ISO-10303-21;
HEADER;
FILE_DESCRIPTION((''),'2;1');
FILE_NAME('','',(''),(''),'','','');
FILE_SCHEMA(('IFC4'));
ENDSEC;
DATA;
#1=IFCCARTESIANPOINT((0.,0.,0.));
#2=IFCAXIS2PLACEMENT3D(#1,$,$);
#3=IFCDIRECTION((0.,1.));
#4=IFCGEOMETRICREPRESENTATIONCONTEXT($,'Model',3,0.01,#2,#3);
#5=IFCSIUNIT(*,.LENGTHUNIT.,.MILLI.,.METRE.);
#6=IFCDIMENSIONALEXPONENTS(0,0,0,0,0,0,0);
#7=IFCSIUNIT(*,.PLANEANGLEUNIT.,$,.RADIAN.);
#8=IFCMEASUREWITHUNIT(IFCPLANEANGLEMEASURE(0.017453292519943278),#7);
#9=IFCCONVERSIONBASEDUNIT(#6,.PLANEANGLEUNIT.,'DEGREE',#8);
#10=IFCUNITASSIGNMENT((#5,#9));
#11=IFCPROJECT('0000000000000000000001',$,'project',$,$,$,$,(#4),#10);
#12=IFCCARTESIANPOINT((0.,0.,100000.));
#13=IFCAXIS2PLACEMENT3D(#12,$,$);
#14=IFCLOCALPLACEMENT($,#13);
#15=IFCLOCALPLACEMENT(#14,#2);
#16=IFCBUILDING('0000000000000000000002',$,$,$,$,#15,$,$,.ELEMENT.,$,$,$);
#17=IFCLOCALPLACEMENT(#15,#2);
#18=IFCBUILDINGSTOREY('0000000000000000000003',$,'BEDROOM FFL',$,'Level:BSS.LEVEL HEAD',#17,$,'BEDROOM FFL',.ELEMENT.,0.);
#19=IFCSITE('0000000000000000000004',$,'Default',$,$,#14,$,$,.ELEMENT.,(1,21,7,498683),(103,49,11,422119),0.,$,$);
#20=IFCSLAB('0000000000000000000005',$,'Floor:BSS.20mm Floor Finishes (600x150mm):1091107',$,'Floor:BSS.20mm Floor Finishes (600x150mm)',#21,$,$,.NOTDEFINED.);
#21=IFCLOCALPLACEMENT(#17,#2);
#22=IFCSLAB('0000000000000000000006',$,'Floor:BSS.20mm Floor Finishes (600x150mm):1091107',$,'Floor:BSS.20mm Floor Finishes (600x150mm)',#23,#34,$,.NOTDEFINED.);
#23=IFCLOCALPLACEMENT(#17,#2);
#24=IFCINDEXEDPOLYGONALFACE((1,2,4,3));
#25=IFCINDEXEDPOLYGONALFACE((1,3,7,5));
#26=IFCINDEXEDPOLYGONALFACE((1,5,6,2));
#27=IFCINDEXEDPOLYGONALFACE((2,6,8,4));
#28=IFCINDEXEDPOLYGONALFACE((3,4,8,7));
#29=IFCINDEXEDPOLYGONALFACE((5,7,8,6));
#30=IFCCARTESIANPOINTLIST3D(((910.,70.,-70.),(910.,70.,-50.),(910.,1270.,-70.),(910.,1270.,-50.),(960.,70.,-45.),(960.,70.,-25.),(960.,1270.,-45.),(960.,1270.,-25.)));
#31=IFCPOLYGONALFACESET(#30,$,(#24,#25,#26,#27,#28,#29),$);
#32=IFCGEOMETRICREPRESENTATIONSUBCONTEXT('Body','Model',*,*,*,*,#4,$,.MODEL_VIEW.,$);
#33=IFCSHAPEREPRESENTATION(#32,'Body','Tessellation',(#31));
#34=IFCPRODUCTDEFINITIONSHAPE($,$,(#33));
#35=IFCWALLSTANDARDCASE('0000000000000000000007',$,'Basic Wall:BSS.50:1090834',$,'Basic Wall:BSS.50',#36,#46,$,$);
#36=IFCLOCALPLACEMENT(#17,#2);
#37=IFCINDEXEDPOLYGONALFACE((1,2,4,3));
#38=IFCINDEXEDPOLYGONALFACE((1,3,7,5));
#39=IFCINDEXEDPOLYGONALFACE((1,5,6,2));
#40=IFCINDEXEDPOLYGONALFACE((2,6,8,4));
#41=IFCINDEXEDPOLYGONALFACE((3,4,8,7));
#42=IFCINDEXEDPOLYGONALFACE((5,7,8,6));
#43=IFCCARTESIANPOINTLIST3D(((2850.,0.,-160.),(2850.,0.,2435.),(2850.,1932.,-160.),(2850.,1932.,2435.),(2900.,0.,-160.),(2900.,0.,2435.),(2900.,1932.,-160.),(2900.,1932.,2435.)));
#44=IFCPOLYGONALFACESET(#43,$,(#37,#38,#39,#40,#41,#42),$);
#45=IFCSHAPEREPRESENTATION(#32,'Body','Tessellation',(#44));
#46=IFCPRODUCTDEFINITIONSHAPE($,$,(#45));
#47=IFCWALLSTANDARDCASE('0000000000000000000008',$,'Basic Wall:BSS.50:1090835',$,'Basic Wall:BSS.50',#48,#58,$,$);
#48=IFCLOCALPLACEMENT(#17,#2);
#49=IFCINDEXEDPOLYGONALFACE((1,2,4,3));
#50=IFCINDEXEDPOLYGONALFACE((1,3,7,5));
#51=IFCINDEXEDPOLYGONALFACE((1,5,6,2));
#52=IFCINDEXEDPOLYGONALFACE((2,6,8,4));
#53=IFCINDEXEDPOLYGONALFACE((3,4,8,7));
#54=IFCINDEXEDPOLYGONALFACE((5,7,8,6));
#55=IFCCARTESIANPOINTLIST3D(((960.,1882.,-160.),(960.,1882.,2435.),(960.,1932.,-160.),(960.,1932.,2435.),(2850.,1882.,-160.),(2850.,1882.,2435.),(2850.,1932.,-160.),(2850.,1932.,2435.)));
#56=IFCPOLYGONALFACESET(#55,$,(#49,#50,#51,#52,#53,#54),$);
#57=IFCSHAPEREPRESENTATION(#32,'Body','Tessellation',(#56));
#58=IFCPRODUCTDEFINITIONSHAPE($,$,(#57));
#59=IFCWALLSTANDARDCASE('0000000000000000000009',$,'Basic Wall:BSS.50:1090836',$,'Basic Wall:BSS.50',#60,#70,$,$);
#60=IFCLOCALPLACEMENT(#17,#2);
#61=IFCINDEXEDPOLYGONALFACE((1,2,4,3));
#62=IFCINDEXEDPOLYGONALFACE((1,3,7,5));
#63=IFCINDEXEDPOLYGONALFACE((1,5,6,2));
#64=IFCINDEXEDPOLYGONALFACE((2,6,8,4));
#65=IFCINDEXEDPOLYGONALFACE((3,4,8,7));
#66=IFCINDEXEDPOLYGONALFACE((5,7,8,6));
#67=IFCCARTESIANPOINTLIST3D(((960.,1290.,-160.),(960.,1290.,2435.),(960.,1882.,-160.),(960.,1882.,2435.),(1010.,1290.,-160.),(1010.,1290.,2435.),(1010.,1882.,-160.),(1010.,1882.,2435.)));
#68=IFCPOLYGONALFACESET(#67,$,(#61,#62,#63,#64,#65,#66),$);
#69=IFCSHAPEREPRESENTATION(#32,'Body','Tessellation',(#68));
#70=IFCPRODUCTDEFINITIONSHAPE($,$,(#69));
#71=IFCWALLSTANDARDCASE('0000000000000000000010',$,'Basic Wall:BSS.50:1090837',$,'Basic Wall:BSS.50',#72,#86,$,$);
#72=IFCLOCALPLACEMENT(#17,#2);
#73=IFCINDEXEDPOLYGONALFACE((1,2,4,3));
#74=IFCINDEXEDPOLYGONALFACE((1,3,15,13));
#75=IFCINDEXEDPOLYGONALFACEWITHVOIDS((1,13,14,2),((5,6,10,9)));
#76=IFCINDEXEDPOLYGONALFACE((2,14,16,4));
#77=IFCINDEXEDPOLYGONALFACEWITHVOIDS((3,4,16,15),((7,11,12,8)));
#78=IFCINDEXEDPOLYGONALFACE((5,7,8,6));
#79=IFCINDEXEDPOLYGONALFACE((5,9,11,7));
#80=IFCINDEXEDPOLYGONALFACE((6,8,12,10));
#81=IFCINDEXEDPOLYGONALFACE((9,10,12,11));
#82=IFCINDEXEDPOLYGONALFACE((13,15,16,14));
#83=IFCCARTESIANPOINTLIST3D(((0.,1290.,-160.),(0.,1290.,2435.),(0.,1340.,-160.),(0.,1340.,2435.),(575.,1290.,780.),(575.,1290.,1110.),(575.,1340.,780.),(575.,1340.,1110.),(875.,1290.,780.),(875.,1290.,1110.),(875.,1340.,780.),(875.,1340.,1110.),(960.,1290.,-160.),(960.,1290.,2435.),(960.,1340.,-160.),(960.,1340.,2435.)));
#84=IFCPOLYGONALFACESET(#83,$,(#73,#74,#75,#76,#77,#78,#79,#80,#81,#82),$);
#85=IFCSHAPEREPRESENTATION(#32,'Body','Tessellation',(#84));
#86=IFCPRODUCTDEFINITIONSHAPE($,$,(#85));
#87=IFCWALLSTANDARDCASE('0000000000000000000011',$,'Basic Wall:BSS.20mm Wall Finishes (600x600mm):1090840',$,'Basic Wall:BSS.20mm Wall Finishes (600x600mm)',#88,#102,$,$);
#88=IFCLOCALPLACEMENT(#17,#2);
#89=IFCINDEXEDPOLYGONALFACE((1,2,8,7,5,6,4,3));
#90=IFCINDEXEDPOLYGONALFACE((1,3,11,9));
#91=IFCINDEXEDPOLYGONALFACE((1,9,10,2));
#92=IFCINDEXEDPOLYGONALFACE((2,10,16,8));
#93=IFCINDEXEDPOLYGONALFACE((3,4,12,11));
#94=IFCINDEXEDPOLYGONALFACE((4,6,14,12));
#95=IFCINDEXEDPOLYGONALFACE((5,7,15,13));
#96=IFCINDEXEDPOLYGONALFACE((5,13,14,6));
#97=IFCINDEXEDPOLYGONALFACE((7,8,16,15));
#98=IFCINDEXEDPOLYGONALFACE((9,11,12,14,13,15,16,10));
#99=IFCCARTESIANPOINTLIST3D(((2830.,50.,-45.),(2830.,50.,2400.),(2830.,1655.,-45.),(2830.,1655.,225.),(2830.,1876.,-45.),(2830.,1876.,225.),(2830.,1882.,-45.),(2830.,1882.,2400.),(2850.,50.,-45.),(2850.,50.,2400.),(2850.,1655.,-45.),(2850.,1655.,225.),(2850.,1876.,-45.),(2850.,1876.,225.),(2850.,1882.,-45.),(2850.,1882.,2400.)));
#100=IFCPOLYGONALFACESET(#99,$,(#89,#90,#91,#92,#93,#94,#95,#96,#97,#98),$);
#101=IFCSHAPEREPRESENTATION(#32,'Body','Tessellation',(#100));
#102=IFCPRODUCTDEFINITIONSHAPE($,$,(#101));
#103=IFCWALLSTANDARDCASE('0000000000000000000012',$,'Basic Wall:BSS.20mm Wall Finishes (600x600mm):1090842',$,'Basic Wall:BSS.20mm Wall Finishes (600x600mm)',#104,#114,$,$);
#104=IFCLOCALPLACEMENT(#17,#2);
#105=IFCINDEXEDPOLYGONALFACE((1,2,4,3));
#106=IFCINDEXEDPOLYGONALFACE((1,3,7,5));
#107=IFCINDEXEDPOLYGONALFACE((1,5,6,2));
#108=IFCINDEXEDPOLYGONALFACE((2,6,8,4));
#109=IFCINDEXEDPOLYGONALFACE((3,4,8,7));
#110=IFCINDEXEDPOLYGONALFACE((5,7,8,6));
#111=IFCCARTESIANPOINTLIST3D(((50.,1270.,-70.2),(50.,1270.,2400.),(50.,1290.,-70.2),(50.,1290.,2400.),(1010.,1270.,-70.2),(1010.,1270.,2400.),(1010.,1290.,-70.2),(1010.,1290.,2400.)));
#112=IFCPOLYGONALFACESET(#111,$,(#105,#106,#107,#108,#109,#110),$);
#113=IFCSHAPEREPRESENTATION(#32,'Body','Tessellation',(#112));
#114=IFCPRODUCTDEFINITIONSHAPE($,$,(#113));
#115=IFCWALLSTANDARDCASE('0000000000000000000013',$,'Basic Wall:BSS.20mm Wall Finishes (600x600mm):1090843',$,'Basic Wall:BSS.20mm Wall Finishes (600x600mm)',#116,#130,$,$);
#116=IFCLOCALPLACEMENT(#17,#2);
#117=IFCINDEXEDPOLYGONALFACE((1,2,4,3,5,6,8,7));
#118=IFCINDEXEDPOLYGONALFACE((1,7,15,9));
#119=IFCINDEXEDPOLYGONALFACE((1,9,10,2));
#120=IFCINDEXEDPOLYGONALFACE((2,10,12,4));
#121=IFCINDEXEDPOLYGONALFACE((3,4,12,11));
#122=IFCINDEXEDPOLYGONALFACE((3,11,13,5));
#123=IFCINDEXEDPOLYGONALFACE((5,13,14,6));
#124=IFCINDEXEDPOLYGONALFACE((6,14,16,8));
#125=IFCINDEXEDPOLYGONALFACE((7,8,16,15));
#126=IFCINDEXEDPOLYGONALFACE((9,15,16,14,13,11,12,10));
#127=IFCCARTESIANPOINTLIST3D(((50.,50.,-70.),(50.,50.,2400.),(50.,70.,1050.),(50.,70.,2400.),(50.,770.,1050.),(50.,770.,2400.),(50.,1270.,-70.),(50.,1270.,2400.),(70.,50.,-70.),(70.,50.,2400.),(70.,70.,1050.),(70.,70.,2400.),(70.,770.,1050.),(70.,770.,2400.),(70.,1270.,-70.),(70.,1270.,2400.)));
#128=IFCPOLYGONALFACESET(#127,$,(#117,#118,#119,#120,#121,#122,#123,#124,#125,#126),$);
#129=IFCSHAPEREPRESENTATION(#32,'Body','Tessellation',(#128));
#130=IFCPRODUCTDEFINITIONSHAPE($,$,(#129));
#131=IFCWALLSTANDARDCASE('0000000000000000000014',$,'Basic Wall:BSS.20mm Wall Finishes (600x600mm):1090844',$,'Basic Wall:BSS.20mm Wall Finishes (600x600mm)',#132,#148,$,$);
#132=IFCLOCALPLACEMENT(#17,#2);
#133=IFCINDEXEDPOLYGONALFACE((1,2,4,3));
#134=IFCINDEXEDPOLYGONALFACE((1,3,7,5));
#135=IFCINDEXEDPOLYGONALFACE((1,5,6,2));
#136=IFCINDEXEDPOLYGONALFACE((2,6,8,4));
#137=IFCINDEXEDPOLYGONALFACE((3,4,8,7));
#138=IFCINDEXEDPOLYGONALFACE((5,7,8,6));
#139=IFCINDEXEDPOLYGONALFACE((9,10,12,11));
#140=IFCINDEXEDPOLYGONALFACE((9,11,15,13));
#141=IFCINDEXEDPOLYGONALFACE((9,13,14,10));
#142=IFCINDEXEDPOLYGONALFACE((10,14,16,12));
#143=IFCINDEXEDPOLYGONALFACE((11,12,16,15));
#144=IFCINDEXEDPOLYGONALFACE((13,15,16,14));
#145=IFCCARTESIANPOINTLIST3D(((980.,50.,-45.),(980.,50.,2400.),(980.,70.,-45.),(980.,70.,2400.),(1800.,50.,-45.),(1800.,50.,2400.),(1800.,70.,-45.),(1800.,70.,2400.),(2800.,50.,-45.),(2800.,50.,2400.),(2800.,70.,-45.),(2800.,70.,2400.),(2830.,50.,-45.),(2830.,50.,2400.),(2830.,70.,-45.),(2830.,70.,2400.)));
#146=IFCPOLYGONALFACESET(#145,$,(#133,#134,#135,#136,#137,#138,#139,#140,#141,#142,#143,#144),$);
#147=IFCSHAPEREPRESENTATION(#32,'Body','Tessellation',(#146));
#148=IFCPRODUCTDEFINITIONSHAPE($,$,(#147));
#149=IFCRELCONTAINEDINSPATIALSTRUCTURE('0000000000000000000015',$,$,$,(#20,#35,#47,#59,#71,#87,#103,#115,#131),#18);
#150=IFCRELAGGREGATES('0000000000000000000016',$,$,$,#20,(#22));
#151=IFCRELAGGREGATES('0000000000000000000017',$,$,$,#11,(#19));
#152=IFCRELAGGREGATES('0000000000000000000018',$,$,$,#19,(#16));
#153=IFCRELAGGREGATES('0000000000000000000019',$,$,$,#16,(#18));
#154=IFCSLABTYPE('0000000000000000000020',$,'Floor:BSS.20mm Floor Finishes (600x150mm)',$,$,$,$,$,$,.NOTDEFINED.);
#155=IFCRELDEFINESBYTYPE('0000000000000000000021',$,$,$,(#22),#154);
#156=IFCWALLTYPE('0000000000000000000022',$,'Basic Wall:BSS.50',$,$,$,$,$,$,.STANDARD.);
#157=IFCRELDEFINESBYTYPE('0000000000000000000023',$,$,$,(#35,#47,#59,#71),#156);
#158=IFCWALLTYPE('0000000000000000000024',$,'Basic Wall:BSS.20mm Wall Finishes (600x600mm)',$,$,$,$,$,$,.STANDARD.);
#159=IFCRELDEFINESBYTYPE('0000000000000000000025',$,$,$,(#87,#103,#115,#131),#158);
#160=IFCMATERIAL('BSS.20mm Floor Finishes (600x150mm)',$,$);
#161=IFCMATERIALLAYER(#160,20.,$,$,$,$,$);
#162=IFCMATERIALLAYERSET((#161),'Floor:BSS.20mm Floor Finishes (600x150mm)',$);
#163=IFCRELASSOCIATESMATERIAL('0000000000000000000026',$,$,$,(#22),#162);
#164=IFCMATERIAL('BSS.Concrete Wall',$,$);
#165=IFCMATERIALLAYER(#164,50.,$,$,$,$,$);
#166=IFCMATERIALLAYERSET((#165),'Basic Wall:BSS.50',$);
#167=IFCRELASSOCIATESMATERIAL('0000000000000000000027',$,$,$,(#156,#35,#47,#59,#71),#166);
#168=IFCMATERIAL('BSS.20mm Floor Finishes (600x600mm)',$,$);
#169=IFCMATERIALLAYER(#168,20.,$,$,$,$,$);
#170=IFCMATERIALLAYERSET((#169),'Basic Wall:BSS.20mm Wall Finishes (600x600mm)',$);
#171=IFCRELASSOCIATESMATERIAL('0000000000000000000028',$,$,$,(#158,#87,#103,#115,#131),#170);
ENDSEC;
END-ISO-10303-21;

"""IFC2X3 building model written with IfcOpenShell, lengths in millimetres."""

from ifc_helpers import new_model, entity, si_unit, converted_unit, direction, frame, frame_2d, origin, place, context, subcontext, project, spatial, rectangle, extrude, material, layer, layer_set, layer_usage, type_object, element, aggregate, save


model = new_model("IFC2X3")

# Units and contexts
model_context = context("Model", 3, precision=0.01, world=origin(), true_north=direction((0.0, 1.0)))
body_context = subcontext(model_context, "Body", "Model", "MODEL_VIEW")
ifc_project = project(units=[si_unit("LENGTHUNIT", "METRE", prefix="MILLI"), converted_unit("PLANEANGLEUNIT", "DEGREE", entity("IfcPlaneAngleMeasure", 0.017453292519943278), si_unit("PLANEANGLEUNIT", "RADIAN"), dimensions=[0, 0, 0, 0, 0, 0, 0])], contexts=[model_context])

# Site, building, storey
site_placement = place(None, frame((0.0, 0.0, 100000.0)))
site = spatial("IfcSite", under=ifc_project, at=site_placement, Name="Default", CompositionType="ELEMENT", RefLatitude=(1, 21, 7, 498683), RefLongitude=(103, 49, 11, 422119), RefElevation=0.0)
building_placement = place(site_placement, origin())
building = spatial("IfcBuilding", under=site, at=building_placement, CompositionType="ELEMENT")
storey_placement = place(building_placement, origin())
storey = spatial("IfcBuildingStorey", under=building, at=storey_placement, Name="BEDROOM FFL", ObjectType="Level:BSS.LEVEL HEAD", LongName="BEDROOM FFL", CompositionType="ELEMENT", Elevation=0.0)

# Slabs
slab_1_placement = place(storey_placement, frame((910.0, 70.0, -70.0)))
slab_1 = element("IfcSlab", 1, at=slab_1_placement, inside=storey, Name="Floor:BSS.20mm Floor Finishes (600x150mm):1091107", ObjectType="Floor:BSS.20mm Floor Finishes (600x150mm)", PredefinedType="NOTDEFINED")
ifc_material_1 = material(Name="BSS.20mm Floor Finishes (600x150mm)")
ifc_layer_1 = layer(ifc_material_1, 20.0)
ifc_layer_set_1 = layer_set([ifc_layer_1], Name="Floor:BSS.20mm Floor Finishes (600x150mm)")
slab_type = type_object("IfcSlabType", Name="Floor:BSS.20mm Floor Finishes (600x150mm)", PredefinedType="NOTDEFINED")
slab_2_placement = place(slab_1_placement, origin())
slab_2 = element("IfcSlab", 2, at=slab_2_placement, type_object=slab_type, material=ifc_layer_set_1, Name="Floor:BSS.20mm Floor Finishes (600x150mm):1091107", ObjectType="Floor:BSS.20mm Floor Finishes (600x150mm)", PredefinedType="NOTDEFINED", context=body_context, shape_type="SweptSolid", body=[
    extrude(rectangle(XDim=1200.0, YDim=55.9, at=frame_2d((0.0, 0.0), x_axis=(0.0, -1.0))), frame((25.0, 600.0, 32.5), z_axis=(-0.447227, 0.0, 0.89442), x_axis=(0.89442, 0.0, 0.447227)), (-0.447227, 0.0, -0.89442), 20.0),
])
aggregate(slab_1, [slab_2])

# Walls
ifc_material_2 = material(Name="BSS.Concrete Wall")
ifc_layer_2 = layer(ifc_material_2, 50.0)
ifc_layer_set_2 = layer_set([ifc_layer_2], Name="Basic Wall:BSS.50")
ifc_layer_usage_1 = layer_usage(ifc_layer_set_2, "AXIS2", "POSITIVE", -25.0)
wall_type_1 = type_object("IfcWallType", Name="Basic Wall:BSS.50", PredefinedType="STANDARD", material=ifc_layer_set_2)
wall_1_placement = place(storey_placement, frame((2875.0, 0.0, -160.0), z_axis=(0.0, 0.0, 1.0), x_axis=(0.0, 1.0, 0.0)))
element("IfcWallStandardCase", 3, at=wall_1_placement, inside=storey, type_object=wall_type_1, material=ifc_layer_usage_1, Name="Basic Wall:BSS.50:1090834", ObjectType="Basic Wall:BSS.50", context=body_context, shape_type="SweptSolid", body=[
    extrude(rectangle(XDim=1932.0, YDim=50.0, at=frame_2d((966.0, 0.0), x_axis=(-1.0, 0.0))), origin(), (0.0, 0.0, 1.0), 2595.0),
])
ifc_layer_usage_2 = layer_usage(ifc_layer_set_2, "AXIS2", "NEGATIVE", 25.0)
wall_2_placement = place(storey_placement, frame((2850.0, 1907.0, -160.0), z_axis=(0.0, 0.0, 1.0), x_axis=(-1.0, 0.0, 0.0)))
element("IfcWallStandardCase", 4, at=wall_2_placement, inside=storey, type_object=wall_type_1, material=ifc_layer_usage_2, Name="Basic Wall:BSS.50:1090835", ObjectType="Basic Wall:BSS.50", context=body_context, shape_type="SweptSolid", body=[
    extrude(rectangle(XDim=1890.0, YDim=50.0, at=frame_2d((945.0, 0.0), x_axis=(-1.0, 0.0))), origin(), (0.0, 0.0, 1.0), 2595.0),
])
ifc_layer_usage_3 = layer_usage(ifc_layer_set_2, "AXIS2", "NEGATIVE", 25.0)
wall_3_placement = place(storey_placement, frame((985.0, 1882.0, -160.0), z_axis=(0.0, 0.0, 1.0), x_axis=(0.0, -1.0, 0.0)))
element("IfcWallStandardCase", 5, at=wall_3_placement, inside=storey, type_object=wall_type_1, material=ifc_layer_usage_3, Name="Basic Wall:BSS.50:1090836", ObjectType="Basic Wall:BSS.50", context=body_context, shape_type="SweptSolid", body=[
    extrude(rectangle(XDim=592.0, YDim=50.0, at=frame_2d((296.0, 0.0), x_axis=(-1.0, 0.0))), origin(), (0.0, 0.0, 1.0), 2595.0),
])

# Walls, openings
ifc_layer_usage_4 = layer_usage(ifc_layer_set_2, "AXIS2", "NEGATIVE", 25.0)
wall_4_placement = place(storey_placement, frame((960.0, 1315.0, -160.0), z_axis=(0.0, 0.0, 1.0), x_axis=(-1.0, 0.0, 0.0)))
wall_4 = element("IfcWallStandardCase", 6, at=wall_4_placement, inside=storey, type_object=wall_type_1, material=ifc_layer_usage_4, Name="Basic Wall:BSS.50:1090837", ObjectType="Basic Wall:BSS.50", context=body_context, shape_type="SweptSolid", body=[
    extrude(rectangle(XDim=960.0, YDim=50.0, at=frame_2d((480.0, 0.0), x_axis=(-1.0, 0.0))), origin(), (0.0, 0.0, 1.0), 2595.0),
])
opening_1_placement = place(wall_4_placement, origin())
element("IfcOpeningElement", 7, at=opening_1_placement, cuts=wall_4, ObjectType="Opening", context=body_context, shape_type="SweptSolid", body=[
    extrude(rectangle(XDim=330.0, YDim=300.0, at=frame_2d((0.0, 0.0), x_axis=(0.0, 1.0))), frame((235.0, 25.0, 1105.0), z_axis=(0.0, -1.0, 0.0), x_axis=(-1.0, 0.0, 0.0)), (0.0, 0.0, 1.0), 50.0),
])
ifc_material_3 = material(Name="BSS.20mm Floor Finishes (600x600mm)")
ifc_layer_3 = layer(ifc_material_3, 20.0)
ifc_layer_set_3 = layer_set([ifc_layer_3], Name="Basic Wall:BSS.20mm Wall Finishes (600x600mm)")
ifc_layer_usage_5 = layer_usage(ifc_layer_set_3, "AXIS2", "POSITIVE", -10.0)
wall_type_2 = type_object("IfcWallType", Name="Basic Wall:BSS.20mm Wall Finishes (600x600mm)", PredefinedType="STANDARD", material=ifc_layer_set_3)
wall_5_placement = place(storey_placement, frame((2840.0, 50.0, -45.0), z_axis=(0.0, 0.0, 1.0), x_axis=(0.0, 1.0, 0.0)))
wall_5 = element("IfcWallStandardCase", 8, at=wall_5_placement, inside=storey, type_object=wall_type_2, material=ifc_layer_usage_5, Name="Basic Wall:BSS.20mm Wall Finishes (600x600mm):1090840", ObjectType="Basic Wall:BSS.20mm Wall Finishes (600x600mm)", context=body_context, shape_type="SweptSolid", body=[
    extrude(rectangle(XDim=1832.0, YDim=20.0, at=frame_2d((916.0, 0.0), x_axis=(-1.0, 0.0))), origin(), (0.0, 0.0, 1.0), 2445.0),
])
opening_2_placement = place(wall_5_placement, origin())
element("IfcOpeningElement", 9, at=opening_2_placement, cuts=wall_5, ObjectType="Opening", context=body_context, shape_type="SweptSolid", body=[
    extrude(rectangle(XDim=270.0, YDim=221.0, at=frame_2d((0.0, 0.0), x_axis=(0.0, 1.0))), frame((1715.5, 10.0, 135.0), z_axis=(0.0, -1.0, 0.0), x_axis=(1.0, 0.0, 0.0)), (0.0, 0.0, 1.0), 20.0),
])

# Wall
ifc_layer_usage_6 = layer_usage(ifc_layer_set_3, "AXIS2", "POSITIVE", -10.0)
wall_6_placement = place(storey_placement, frame((1010.0, 1280.0, -70.2), z_axis=(0.0, 0.0, 1.0), x_axis=(-1.0, 0.0, 0.0)))
element("IfcWallStandardCase", 10, at=wall_6_placement, inside=storey, type_object=wall_type_2, material=ifc_layer_usage_6, Name="Basic Wall:BSS.20mm Wall Finishes (600x600mm):1090842", ObjectType="Basic Wall:BSS.20mm Wall Finishes (600x600mm)", context=body_context, shape_type="SweptSolid", body=[
    extrude(rectangle(XDim=960.0, YDim=20.0, at=frame_2d((480.0, 0.0), x_axis=(-1.0, 0.0))), origin(), (0.0, 0.0, 1.0), 2470.2),
])

# Walls, openings
ifc_layer_usage_7 = layer_usage(ifc_layer_set_3, "AXIS2", "POSITIVE", -10.0)
wall_7_placement = place(storey_placement, frame((60.0, 1270.0, -70.0), z_axis=(0.0, 0.0, 1.0), x_axis=(0.0, -1.0, 0.0)))
wall_7 = element("IfcWallStandardCase", 11, at=wall_7_placement, inside=storey, type_object=wall_type_2, material=ifc_layer_usage_7, Name="Basic Wall:BSS.20mm Wall Finishes (600x600mm):1090843", ObjectType="Basic Wall:BSS.20mm Wall Finishes (600x600mm)", context=body_context, shape_type="SweptSolid", body=[
    extrude(rectangle(XDim=1220.0, YDim=20.0, at=frame_2d((610.0, 0.0), x_axis=(-1.0, 0.0))), origin(), (0.0, 0.0, 1.0), 2470.0),
])
opening_3_placement = place(wall_7_placement, frame((1270.0, -60.0, 70.0), z_axis=(0.0, 0.0, 1.0), x_axis=(0.0, 1.0, 0.0)))
element("IfcOpeningElement", 12, at=opening_3_placement, cuts=wall_7, ObjectType="Opening", context=body_context, shape_type="SweptSolid", body=[
    extrude(rectangle(XDim=1350.0, YDim=700.0, at=frame_2d((0.0, 0.0), x_axis=(0.0, 1.0))), frame((-1474.0, 420.0, 1725.0), z_axis=(1.0, 0.0, 0.0), x_axis=(0.0, -1.0, 0.0)), (0.0, 0.0, 1.0), 3048.0),
])
ifc_layer_usage_8 = layer_usage(ifc_layer_set_3, "AXIS2", "POSITIVE", -10.0)
wall_8_placement = place(storey_placement, frame((980.0, 60.0, -45.0)))
wall_8 = element("IfcWallStandardCase", 13, at=wall_8_placement, inside=storey, type_object=wall_type_2, material=ifc_layer_usage_8, Name="Basic Wall:BSS.20mm Wall Finishes (600x600mm):1090844", ObjectType="Basic Wall:BSS.20mm Wall Finishes (600x600mm)", context=body_context, shape_type="SweptSolid", body=[
    extrude(rectangle(XDim=1850.0, YDim=20.0, at=frame_2d((925.0, 0.0), x_axis=(-1.0, 0.0))), origin(), (0.0, 0.0, 1.0), 2445.0),
])
opening_4_placement = place(wall_8_placement, frame((-980.0, -60.0, 45.0)))
element("IfcOpeningElement", 14, at=opening_4_placement, cuts=wall_8, ObjectType="Opening", context=body_context, shape_type="SweptSolid", body=[
    extrude(rectangle(XDim=2445.0, YDim=1000.0, at=frame_2d((0.0, 0.0), x_axis=(1.0, 0.0))), frame((2300.0, -1474.0, 1177.5), z_axis=(0.0, 1.0, 0.0), x_axis=(0.0, 0.0, -1.0)), (0.0, 0.0, 1.0), 3048.0),
])

save(model, "model.ifc")
